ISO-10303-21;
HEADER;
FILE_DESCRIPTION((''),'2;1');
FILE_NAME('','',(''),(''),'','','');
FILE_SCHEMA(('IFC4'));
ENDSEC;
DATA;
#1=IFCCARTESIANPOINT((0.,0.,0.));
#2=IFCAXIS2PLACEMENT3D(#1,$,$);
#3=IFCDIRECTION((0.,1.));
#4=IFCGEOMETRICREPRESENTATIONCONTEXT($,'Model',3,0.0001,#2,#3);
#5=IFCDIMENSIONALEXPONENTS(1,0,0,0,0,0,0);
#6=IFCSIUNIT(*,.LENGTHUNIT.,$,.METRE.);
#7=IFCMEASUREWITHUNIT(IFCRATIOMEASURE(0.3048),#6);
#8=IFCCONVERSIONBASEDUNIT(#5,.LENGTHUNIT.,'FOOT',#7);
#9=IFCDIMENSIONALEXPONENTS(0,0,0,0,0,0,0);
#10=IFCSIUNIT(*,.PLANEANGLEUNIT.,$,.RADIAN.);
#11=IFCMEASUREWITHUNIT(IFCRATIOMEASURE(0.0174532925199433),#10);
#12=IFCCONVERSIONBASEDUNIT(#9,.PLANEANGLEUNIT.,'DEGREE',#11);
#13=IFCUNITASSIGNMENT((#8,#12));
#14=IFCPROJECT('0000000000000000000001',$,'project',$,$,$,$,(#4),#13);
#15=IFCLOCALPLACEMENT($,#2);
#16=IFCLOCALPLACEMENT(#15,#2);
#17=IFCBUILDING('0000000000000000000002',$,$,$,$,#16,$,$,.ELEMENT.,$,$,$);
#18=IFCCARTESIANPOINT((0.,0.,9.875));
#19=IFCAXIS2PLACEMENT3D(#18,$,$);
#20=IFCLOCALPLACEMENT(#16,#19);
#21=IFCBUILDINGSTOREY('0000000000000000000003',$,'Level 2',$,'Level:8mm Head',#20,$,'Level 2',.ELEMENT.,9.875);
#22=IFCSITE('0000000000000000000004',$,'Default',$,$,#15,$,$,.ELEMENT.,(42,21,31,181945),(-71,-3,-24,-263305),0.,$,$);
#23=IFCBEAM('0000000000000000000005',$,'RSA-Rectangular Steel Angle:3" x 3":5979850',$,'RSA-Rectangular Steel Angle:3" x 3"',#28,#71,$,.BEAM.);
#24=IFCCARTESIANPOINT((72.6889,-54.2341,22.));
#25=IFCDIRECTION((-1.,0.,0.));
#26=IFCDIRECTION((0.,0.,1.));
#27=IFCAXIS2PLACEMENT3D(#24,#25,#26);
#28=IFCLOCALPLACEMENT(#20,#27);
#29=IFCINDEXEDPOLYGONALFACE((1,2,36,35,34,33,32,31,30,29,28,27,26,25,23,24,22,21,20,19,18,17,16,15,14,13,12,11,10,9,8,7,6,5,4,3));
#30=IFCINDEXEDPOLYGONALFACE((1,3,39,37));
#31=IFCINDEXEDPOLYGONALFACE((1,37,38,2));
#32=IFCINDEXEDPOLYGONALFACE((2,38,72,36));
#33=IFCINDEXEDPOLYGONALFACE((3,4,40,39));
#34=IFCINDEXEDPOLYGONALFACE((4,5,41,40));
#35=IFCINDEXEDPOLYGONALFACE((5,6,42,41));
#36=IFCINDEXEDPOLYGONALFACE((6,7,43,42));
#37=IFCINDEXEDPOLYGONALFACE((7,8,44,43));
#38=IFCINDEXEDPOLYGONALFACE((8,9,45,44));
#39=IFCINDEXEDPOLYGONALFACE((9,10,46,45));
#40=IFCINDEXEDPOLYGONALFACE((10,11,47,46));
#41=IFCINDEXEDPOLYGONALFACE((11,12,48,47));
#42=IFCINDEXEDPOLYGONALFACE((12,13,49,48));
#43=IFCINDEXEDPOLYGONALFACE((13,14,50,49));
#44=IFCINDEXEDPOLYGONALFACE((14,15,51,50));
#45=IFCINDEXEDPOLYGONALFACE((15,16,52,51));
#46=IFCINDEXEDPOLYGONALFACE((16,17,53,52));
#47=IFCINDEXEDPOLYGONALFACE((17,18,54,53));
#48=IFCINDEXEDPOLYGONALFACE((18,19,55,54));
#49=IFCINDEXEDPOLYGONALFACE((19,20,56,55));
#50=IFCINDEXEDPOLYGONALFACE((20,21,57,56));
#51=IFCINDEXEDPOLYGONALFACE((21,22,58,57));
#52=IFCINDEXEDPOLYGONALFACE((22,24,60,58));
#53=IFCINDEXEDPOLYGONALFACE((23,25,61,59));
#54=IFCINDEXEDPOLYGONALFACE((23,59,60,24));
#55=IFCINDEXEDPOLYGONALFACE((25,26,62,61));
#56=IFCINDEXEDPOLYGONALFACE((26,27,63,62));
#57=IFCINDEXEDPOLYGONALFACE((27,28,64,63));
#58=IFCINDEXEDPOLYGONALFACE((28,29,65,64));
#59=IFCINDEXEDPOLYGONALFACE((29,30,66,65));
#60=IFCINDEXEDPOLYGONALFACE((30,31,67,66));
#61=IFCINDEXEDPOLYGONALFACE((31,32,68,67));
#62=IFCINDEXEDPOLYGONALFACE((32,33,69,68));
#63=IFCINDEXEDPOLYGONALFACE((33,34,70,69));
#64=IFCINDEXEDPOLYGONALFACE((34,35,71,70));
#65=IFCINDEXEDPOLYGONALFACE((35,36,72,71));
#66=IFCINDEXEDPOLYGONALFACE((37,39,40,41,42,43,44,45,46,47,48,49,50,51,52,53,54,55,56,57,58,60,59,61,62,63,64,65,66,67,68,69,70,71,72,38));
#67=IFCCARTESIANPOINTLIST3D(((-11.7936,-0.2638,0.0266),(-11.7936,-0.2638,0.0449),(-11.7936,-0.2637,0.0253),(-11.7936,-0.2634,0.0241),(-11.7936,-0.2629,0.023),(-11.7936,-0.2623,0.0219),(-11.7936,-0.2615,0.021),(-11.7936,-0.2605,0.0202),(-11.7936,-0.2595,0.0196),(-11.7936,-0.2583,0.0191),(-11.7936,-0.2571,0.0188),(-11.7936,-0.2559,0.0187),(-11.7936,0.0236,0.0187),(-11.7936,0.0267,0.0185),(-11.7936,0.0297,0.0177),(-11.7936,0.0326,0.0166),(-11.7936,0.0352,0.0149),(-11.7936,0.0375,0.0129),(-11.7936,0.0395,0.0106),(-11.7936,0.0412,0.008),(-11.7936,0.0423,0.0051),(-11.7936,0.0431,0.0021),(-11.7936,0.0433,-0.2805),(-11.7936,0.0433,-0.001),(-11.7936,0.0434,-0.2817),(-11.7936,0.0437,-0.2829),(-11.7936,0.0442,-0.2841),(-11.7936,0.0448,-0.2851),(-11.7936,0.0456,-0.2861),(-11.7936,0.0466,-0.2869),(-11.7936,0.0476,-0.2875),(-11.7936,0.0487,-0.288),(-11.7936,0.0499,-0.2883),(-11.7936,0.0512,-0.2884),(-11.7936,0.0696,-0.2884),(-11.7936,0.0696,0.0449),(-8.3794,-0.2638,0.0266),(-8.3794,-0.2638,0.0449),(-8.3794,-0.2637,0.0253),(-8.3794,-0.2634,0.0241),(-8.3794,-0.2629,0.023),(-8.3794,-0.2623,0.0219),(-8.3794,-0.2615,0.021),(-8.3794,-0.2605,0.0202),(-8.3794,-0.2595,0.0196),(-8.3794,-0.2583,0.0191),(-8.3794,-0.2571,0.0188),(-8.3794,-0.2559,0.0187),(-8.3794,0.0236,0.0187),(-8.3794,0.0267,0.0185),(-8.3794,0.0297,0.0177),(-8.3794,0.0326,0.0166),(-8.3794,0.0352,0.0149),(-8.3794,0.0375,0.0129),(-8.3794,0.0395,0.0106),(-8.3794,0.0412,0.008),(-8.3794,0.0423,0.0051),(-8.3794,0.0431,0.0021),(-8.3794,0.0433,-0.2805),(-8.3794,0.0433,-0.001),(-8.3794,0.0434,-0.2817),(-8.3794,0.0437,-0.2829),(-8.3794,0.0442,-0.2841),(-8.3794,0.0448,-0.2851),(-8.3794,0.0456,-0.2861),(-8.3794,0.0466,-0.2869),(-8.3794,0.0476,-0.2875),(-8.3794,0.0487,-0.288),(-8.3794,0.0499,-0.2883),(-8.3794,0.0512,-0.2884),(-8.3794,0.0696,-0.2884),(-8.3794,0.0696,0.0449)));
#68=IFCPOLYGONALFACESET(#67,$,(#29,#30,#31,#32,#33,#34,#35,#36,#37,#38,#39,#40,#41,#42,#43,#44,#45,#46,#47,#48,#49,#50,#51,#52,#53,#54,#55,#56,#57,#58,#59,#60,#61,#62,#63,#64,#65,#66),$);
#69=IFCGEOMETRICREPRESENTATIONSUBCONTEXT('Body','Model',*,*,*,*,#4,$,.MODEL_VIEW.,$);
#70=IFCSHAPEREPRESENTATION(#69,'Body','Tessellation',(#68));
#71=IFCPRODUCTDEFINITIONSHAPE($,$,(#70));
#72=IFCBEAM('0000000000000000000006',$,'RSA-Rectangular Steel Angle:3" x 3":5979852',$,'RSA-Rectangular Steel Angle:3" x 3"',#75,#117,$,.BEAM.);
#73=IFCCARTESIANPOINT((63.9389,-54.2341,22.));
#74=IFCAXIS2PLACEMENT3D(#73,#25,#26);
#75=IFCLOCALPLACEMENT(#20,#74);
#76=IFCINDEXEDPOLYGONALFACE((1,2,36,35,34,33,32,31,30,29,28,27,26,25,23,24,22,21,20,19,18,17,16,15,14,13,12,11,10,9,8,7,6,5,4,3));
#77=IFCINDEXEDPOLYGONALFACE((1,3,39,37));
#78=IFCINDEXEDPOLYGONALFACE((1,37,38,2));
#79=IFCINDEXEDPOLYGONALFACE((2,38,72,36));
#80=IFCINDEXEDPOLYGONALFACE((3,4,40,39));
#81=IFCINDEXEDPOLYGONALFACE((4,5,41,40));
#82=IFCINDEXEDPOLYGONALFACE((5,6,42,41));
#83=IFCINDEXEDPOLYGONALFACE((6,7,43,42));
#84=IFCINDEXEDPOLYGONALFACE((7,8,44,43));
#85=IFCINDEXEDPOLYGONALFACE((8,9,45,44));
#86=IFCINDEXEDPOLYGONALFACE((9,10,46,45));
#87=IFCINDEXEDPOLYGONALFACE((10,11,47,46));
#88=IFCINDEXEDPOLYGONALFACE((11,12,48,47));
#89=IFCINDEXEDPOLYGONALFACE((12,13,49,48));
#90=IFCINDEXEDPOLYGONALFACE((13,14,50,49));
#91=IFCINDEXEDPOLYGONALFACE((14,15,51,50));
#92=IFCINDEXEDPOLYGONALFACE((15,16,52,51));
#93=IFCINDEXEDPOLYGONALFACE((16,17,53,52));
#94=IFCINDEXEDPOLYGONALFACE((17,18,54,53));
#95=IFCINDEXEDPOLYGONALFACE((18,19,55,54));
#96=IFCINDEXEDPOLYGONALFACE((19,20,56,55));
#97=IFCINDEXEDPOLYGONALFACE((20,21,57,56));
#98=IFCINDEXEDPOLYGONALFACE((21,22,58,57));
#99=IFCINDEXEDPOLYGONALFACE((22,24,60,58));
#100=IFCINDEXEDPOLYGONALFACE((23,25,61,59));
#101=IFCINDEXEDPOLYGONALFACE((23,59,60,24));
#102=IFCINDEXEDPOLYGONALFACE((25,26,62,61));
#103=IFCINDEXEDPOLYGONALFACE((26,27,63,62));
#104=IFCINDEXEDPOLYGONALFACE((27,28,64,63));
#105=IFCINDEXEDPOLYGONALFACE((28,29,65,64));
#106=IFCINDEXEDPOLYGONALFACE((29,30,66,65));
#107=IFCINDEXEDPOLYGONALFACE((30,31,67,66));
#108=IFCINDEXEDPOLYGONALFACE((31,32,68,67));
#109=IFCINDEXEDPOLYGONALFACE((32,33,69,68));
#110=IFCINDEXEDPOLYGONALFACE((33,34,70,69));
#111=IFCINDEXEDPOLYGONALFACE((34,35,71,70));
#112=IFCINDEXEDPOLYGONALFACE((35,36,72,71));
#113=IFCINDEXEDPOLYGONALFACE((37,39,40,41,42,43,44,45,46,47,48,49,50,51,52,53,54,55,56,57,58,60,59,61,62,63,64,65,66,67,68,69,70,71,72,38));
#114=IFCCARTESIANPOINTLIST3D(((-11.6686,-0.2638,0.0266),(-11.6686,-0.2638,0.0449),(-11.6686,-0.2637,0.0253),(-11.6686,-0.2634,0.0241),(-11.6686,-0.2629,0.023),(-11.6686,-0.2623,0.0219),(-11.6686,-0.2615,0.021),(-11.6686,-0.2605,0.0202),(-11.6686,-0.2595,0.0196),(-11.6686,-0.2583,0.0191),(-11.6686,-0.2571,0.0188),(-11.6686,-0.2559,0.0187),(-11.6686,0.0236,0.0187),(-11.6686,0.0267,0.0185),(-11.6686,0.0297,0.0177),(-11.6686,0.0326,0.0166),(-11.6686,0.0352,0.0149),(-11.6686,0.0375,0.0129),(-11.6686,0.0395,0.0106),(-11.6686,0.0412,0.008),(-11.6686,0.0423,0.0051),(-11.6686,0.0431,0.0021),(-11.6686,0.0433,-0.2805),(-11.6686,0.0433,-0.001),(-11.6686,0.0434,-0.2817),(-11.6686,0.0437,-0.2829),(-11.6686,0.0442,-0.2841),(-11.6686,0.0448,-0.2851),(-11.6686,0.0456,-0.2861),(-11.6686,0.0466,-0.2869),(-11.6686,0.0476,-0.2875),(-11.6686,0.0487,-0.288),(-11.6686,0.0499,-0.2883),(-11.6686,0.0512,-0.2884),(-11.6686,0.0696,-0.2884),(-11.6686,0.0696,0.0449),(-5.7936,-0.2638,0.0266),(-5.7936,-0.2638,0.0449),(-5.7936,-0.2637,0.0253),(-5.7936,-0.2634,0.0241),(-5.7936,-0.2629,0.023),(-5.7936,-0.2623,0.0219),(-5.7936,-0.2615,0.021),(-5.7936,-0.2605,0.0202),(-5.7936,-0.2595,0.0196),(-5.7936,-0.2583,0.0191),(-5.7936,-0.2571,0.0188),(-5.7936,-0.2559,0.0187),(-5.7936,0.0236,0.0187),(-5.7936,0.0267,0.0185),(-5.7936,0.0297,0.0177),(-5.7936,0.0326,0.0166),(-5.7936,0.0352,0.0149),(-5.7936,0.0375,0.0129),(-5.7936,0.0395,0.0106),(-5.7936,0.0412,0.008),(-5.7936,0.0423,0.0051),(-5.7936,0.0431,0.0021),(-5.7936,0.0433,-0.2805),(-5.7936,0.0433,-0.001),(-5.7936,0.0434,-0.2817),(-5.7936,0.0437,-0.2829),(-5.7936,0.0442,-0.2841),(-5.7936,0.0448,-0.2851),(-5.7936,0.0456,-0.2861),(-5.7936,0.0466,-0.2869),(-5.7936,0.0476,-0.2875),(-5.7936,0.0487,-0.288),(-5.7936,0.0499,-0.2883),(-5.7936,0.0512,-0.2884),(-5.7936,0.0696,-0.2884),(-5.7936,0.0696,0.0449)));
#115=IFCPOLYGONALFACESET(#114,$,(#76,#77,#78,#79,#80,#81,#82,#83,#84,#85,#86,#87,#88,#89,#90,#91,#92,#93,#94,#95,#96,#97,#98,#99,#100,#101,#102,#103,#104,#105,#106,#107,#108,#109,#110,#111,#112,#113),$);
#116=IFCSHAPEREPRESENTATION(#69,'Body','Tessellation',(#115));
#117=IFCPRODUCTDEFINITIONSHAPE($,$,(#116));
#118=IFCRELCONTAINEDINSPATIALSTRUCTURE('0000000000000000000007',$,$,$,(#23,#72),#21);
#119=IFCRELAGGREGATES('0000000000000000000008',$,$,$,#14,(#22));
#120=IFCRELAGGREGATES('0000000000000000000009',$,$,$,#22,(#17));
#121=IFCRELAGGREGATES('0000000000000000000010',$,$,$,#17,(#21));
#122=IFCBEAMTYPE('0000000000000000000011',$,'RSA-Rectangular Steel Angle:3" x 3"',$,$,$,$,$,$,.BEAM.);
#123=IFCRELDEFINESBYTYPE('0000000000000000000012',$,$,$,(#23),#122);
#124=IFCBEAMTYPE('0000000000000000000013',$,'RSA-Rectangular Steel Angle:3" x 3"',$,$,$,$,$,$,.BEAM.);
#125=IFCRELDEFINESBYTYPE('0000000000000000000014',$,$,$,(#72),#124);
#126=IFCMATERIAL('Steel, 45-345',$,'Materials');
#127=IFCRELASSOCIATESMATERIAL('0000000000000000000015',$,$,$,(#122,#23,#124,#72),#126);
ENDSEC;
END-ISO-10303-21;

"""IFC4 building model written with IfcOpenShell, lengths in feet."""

from ifc_helpers import new_model, entity, si_unit, converted_unit, direction, frame, origin, place, context, subcontext, project, spatial, indexed_curve, outline, extrude, source, transform, mapped, material, type_object, type_shapes, element, save


model = new_model("IFC4")

# Units and contexts
model_context = context("Model", 3, precision=0.0001, world=origin(), true_north=direction((0.0, 1.0)))
body_context = subcontext(model_context, "Body", "Model", "MODEL_VIEW")
ifc_project = project(units=[converted_unit("LENGTHUNIT", "FOOT", entity("IfcRatioMeasure", 0.3048), si_unit("LENGTHUNIT", "METRE"), dimensions=[1, 0, 0, 0, 0, 0, 0]), converted_unit("PLANEANGLEUNIT", "DEGREE", entity("IfcRatioMeasure", 0.0174532925199433), si_unit("PLANEANGLEUNIT", "RADIAN"), dimensions=[0, 0, 0, 0, 0, 0, 0])], contexts=[model_context])

# Site, building, storey
site_placement = place(None, origin())
site = spatial("IfcSite", under=ifc_project, at=site_placement, Name="Default", CompositionType="ELEMENT", RefLatitude=(42, 21, 31, 181945), RefLongitude=(-71, -3, -24, -263305), RefElevation=0.0)
building_placement = place(site_placement, origin())
building = spatial("IfcBuilding", under=site, at=building_placement, CompositionType="ELEMENT")
storey_placement = place(building_placement, frame((0.0, 0.0, 9.875)))
storey = spatial("IfcBuildingStorey", under=building, at=storey_placement, Name="Level 2", ObjectType="Level:8mm Head", LongName="Level 2", CompositionType="ELEMENT", Elevation=9.875)

# Beams
ifc_material_1 = material(Name="Steel, 45-345", Category="Materials")
beam_type_1 = type_object("IfcBeamType", Name="RSA-Rectangular Steel Angle:3\" x 3\"", PredefinedType="BEAM", material=ifc_material_1)
shared_shape_1 = source(origin(), body_context, "Body", "SweptSolid", [
    extrude(outline(indexed_curve([(-0.1232, -0.2101), (-0.1048, -0.2101), (-0.1036, -0.21), (-0.1024, -0.2097), (-0.1013, -0.2093), (-0.1002, -0.2086), (-0.0993, -0.2078), (-0.0985, -0.2069), (-0.0978, -0.2058), (-0.0974, -0.2047), (-0.0971, -0.2035), (-0.097, -0.2022), (-0.097, 0.0773), (-0.0967, 0.0804), (-0.096, 0.0834), (-0.0948, 0.0862), (-0.0932, 0.0889), (-0.0912, 0.0912), (-0.0889, 0.0932), (-0.0862, 0.0948), (-0.0834, 0.096), (-0.0804, 0.0967), (-0.0773, 0.097), (0.2022, 0.097), (0.2035, 0.0971), (0.2047, 0.0974), (0.2058, 0.0978), (0.2069, 0.0985), (0.2078, 0.0993), (0.2086, 0.1002), (0.2093, 0.1013), (0.2097, 0.1024), (0.21, 0.1036), (0.2101, 0.1048), (0.2101, 0.1232), (-0.1232, 0.1232), (-0.1232, -0.2101)], self_intersect=False)), frame((-11.7936, -0.0537, -0.0783), z_axis=(1.0, 0.0, 0.0), x_axis=(0.0, 0.0, -1.0)), (0.0, 0.0, 1.0), 3.4142),
])
type_shapes(beam_type_1, [shared_shape_1])
beam_1_placement = place(storey_placement, frame((72.6889, -54.2341, 22.0), z_axis=(-1.0, 0.0, 0.0), x_axis=(0.0, 0.0, 1.0)))
element("IfcBeam", 1, at=beam_1_placement, inside=storey, type_object=beam_type_1, material=ifc_material_1, Name="RSA-Rectangular Steel Angle:3\" x 3\":5979850", ObjectType="RSA-Rectangular Steel Angle:3\" x 3\"", PredefinedType="BEAM", context=body_context, shape_type="MappedRepresentation", body=[
    mapped(shared_shape_1, transform((0.0, 0.0, 0.0), scale=1.0)),
])
beam_type_2 = type_object("IfcBeamType", Name="RSA-Rectangular Steel Angle:3\" x 3\"", PredefinedType="BEAM", material=ifc_material_1)
shared_shape_2 = source(origin(), body_context, "Body", "SweptSolid", [
    extrude(outline(indexed_curve([(-0.1232, -0.2101), (-0.1048, -0.2101), (-0.1036, -0.21), (-0.1024, -0.2097), (-0.1013, -0.2093), (-0.1002, -0.2086), (-0.0993, -0.2078), (-0.0985, -0.2069), (-0.0978, -0.2058), (-0.0974, -0.2047), (-0.0971, -0.2035), (-0.097, -0.2022), (-0.097, 0.0773), (-0.0967, 0.0804), (-0.096, 0.0834), (-0.0948, 0.0862), (-0.0932, 0.0889), (-0.0912, 0.0912), (-0.0889, 0.0932), (-0.0862, 0.0948), (-0.0834, 0.096), (-0.0804, 0.0967), (-0.0773, 0.097), (0.2022, 0.097), (0.2035, 0.0971), (0.2047, 0.0974), (0.2058, 0.0978), (0.2069, 0.0985), (0.2078, 0.0993), (0.2086, 0.1002), (0.2093, 0.1013), (0.2097, 0.1024), (0.21, 0.1036), (0.2101, 0.1048), (0.2101, 0.1232), (-0.1232, 0.1232), (-0.1232, -0.2101)], self_intersect=False)), frame((-11.6686, -0.0537, -0.0783), z_axis=(1.0, 0.0, 0.0), x_axis=(0.0, 0.0, -1.0)), (0.0, 0.0, 1.0), 5.875),
])
type_shapes(beam_type_2, [shared_shape_2])
beam_2_placement = place(storey_placement, frame((63.9389, -54.2341, 22.0), z_axis=(-1.0, 0.0, 0.0), x_axis=(0.0, 0.0, 1.0)))
element("IfcBeam", 2, at=beam_2_placement, inside=storey, type_object=beam_type_2, material=ifc_material_1, Name="RSA-Rectangular Steel Angle:3\" x 3\":5979852", ObjectType="RSA-Rectangular Steel Angle:3\" x 3\"", PredefinedType="BEAM", context=body_context, shape_type="MappedRepresentation", body=[
    mapped(shared_shape_2, transform((0.0, 0.0, 0.0), scale=1.0)),
])

save(model, "model.ifc")
